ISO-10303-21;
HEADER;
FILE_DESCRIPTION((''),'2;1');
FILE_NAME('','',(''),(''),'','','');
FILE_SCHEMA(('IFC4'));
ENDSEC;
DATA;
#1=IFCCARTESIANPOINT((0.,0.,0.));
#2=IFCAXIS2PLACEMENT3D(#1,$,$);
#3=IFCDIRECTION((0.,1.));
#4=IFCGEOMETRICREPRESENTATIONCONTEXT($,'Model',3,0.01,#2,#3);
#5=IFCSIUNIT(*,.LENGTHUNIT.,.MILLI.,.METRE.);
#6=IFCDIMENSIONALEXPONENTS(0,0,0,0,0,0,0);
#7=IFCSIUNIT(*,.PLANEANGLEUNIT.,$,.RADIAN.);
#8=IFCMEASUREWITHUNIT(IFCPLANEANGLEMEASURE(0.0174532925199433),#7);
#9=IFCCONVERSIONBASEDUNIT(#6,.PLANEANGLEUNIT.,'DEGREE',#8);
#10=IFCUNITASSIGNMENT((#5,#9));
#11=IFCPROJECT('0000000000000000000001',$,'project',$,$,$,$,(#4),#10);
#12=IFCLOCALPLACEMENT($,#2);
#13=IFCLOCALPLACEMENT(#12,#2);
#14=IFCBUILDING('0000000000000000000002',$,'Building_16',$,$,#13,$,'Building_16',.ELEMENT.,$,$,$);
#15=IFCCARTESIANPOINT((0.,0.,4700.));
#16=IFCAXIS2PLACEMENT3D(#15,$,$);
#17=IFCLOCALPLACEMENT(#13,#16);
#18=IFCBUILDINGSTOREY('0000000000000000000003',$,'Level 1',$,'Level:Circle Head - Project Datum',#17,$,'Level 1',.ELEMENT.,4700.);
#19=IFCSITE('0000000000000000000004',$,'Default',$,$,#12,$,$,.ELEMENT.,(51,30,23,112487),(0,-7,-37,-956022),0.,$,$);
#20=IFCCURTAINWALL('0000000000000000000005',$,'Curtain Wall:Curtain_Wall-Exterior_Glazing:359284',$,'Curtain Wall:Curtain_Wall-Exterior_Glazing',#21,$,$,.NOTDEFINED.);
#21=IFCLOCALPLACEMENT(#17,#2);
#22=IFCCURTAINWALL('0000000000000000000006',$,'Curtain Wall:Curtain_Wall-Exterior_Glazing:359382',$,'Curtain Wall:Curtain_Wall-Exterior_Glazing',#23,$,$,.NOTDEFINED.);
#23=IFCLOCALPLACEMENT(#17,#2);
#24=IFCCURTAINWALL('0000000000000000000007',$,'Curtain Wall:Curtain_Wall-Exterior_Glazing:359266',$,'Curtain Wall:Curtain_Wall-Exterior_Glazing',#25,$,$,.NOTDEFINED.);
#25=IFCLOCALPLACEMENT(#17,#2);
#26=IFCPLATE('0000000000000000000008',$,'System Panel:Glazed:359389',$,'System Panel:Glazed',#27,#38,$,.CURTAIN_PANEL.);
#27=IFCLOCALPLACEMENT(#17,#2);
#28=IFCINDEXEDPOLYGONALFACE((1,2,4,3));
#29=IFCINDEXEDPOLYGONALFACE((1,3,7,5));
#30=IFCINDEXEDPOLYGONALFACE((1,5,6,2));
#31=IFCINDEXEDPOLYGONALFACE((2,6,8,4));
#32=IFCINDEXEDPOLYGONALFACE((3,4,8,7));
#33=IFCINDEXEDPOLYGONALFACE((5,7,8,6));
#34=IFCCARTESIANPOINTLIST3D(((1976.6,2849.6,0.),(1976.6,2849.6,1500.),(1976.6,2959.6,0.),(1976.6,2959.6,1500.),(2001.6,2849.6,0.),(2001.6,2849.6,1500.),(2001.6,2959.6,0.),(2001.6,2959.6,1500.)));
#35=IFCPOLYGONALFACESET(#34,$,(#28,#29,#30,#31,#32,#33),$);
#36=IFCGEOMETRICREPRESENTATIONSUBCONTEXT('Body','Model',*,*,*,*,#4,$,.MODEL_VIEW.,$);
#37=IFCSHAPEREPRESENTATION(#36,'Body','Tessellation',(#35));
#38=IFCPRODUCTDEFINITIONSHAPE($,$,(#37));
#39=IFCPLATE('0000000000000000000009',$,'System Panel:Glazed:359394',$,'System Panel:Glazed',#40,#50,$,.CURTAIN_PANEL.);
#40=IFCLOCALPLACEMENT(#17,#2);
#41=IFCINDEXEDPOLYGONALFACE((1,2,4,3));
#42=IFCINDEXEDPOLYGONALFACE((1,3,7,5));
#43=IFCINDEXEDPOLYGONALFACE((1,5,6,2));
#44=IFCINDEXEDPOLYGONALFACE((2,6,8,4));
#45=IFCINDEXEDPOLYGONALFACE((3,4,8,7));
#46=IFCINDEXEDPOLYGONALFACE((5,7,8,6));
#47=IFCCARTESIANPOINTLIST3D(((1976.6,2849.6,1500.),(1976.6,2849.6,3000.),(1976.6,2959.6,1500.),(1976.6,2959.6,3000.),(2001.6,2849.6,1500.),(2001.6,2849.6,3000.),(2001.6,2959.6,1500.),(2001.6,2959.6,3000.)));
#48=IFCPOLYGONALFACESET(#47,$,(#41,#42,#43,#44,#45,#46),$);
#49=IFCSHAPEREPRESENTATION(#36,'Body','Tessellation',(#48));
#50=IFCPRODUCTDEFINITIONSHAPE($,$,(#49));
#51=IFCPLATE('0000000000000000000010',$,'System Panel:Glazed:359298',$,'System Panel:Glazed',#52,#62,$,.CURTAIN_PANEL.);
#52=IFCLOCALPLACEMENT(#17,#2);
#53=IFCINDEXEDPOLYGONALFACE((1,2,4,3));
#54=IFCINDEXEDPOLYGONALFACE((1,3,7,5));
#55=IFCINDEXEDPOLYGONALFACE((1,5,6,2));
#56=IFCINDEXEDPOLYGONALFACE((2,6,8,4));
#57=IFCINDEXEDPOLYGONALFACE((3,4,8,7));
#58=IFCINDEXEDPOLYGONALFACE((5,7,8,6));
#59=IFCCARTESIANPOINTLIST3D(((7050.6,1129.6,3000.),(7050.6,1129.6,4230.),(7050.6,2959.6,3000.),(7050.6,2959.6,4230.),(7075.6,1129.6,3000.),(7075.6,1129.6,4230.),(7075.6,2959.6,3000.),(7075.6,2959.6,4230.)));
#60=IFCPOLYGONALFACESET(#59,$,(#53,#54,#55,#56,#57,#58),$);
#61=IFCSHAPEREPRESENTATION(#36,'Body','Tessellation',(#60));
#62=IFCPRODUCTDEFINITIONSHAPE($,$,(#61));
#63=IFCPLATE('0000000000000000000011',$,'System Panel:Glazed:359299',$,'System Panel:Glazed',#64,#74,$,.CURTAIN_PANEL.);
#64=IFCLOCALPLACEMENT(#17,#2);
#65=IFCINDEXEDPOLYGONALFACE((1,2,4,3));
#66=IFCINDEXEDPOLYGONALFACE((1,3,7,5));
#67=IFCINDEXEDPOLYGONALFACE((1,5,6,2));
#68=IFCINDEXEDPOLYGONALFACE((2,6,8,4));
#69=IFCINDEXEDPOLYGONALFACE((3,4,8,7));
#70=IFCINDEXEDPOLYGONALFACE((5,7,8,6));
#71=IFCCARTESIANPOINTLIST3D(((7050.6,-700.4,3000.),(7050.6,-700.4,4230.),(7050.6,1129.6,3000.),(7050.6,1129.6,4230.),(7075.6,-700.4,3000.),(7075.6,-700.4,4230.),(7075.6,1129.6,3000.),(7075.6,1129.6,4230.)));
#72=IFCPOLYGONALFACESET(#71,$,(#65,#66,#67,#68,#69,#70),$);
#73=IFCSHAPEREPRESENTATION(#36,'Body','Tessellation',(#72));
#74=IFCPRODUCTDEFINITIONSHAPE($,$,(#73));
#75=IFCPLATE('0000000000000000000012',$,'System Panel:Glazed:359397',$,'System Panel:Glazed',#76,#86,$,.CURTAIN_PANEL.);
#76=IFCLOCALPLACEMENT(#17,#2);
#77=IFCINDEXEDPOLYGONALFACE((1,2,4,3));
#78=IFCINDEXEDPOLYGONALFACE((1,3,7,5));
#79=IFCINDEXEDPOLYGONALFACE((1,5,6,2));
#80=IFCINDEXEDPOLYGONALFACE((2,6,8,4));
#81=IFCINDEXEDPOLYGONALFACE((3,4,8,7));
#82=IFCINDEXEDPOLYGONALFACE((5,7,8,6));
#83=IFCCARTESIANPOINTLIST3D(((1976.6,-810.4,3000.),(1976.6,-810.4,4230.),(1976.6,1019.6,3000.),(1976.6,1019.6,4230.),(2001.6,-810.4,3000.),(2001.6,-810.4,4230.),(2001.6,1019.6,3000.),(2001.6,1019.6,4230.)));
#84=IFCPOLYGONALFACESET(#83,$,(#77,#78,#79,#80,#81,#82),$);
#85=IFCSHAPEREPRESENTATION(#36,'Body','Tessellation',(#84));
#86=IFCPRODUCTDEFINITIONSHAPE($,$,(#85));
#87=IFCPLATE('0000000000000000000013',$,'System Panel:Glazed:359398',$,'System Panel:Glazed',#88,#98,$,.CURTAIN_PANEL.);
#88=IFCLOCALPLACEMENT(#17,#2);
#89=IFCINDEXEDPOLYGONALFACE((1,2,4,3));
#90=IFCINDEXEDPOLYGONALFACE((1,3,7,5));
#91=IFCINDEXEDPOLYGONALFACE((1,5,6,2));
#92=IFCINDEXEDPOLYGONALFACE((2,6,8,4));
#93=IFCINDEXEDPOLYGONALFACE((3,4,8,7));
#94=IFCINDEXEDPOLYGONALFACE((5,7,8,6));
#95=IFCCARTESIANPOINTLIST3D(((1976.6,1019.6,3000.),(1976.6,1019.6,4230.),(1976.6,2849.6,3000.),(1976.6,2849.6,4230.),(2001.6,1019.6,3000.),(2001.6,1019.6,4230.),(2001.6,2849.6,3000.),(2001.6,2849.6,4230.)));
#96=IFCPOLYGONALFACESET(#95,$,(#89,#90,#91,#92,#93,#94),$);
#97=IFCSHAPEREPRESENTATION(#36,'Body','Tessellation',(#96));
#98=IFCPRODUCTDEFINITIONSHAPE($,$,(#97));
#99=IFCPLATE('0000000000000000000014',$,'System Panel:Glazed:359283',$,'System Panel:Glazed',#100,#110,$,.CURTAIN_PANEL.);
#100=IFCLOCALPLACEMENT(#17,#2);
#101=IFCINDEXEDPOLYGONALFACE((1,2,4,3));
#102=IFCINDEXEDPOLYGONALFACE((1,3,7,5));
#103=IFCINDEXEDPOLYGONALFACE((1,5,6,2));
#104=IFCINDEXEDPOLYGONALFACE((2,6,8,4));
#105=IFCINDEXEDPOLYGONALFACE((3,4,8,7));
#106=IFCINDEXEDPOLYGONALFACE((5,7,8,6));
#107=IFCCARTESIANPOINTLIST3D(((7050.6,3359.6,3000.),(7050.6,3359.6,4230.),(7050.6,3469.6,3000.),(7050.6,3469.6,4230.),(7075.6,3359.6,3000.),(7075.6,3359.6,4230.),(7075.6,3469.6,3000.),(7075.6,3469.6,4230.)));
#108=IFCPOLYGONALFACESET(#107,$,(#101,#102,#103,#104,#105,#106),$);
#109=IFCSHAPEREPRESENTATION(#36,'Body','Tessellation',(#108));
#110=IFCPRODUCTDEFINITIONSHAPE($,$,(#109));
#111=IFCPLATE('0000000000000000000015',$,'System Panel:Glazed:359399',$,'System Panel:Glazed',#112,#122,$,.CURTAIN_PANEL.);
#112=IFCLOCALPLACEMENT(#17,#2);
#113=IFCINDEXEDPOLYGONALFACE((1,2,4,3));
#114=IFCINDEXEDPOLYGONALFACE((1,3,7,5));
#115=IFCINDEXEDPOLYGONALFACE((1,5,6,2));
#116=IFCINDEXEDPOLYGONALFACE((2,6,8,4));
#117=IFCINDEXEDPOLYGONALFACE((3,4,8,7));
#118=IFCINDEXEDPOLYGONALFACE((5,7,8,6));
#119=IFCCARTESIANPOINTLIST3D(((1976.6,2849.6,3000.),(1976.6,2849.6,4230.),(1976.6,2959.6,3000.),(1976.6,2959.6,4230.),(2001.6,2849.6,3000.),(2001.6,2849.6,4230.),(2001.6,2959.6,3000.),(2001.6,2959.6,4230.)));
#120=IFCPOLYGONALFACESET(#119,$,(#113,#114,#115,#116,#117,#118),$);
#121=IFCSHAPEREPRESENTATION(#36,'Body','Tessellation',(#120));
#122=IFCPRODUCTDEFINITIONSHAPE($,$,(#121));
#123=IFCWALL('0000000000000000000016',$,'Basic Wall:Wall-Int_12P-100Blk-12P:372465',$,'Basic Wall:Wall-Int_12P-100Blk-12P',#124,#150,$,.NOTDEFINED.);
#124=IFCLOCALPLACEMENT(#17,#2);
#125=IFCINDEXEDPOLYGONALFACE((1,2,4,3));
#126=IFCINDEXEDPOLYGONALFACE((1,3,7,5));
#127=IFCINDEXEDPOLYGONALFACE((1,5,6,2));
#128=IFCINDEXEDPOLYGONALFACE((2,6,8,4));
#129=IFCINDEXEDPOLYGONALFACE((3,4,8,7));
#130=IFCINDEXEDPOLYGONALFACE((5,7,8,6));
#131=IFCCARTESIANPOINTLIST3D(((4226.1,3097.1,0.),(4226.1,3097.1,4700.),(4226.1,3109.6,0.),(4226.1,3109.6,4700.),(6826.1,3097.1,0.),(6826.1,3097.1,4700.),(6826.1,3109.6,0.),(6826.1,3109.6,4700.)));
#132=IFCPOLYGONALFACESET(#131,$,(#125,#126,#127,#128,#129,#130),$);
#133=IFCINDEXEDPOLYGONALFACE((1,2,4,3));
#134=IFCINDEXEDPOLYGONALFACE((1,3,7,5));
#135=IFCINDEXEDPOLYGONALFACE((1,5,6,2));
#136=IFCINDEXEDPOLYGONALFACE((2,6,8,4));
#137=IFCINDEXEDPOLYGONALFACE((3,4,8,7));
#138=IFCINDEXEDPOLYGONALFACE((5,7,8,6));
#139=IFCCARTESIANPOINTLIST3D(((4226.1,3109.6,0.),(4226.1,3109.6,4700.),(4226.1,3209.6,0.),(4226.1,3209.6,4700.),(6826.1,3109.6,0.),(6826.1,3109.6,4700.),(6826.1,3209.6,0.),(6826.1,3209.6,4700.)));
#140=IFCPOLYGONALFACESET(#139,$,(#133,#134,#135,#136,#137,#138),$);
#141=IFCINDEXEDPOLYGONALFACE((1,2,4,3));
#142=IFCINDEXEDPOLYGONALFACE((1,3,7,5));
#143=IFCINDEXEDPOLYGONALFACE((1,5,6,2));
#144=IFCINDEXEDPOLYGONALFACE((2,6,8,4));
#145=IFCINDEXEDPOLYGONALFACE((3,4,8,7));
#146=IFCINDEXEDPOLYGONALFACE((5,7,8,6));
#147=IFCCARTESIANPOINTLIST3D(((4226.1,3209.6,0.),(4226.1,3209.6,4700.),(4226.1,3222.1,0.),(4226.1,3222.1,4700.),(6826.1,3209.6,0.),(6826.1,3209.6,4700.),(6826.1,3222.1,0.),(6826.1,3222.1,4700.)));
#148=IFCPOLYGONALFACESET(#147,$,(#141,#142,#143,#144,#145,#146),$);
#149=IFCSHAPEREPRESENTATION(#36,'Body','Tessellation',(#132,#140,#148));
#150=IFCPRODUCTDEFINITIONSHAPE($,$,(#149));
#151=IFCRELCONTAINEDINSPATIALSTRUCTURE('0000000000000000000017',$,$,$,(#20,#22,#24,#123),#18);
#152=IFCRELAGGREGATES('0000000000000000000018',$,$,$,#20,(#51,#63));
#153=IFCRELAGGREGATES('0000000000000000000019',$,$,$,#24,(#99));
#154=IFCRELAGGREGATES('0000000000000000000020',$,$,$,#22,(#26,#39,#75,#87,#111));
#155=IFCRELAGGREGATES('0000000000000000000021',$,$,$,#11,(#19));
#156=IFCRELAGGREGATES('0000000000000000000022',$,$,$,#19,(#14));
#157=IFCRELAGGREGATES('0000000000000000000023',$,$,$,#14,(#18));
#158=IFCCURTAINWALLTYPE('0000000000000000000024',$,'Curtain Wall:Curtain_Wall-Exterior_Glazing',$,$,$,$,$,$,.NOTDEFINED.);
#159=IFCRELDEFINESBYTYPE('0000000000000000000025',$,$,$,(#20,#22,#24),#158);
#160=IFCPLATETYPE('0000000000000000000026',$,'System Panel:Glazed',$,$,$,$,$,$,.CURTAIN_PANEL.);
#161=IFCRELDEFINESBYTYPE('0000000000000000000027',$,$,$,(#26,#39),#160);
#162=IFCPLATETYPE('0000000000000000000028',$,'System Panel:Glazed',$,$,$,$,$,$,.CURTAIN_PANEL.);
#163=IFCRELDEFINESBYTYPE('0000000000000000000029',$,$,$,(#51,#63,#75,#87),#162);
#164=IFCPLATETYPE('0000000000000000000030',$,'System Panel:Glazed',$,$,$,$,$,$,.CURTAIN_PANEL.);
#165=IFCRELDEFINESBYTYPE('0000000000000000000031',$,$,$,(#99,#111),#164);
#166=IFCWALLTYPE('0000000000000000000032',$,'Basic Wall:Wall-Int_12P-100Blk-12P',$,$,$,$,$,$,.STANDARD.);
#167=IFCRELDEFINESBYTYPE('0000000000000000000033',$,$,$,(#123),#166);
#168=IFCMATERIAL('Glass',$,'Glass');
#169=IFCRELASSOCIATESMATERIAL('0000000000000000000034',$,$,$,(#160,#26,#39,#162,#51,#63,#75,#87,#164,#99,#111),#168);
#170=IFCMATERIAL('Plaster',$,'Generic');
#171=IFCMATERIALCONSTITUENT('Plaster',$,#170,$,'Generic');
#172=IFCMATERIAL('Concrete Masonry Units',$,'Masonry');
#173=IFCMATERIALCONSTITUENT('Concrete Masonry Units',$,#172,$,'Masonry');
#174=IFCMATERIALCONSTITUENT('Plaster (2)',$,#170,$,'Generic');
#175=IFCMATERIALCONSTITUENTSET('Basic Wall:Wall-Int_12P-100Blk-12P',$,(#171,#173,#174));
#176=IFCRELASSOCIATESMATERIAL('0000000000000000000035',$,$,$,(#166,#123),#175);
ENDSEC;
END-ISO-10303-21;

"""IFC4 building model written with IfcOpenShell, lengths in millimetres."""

from ifc_helpers import new_model, entity, si_unit, converted_unit, direction, frame, origin, place, context, subcontext, project, spatial, indexed_curve, outline, extrude, source, transform, mapped, material, constituent, constituent_set, type_object, type_shapes, element, aggregate, save


model = new_model("IFC4")

# Units and contexts
model_context = context("Model", 3, precision=0.01, world=origin(), true_north=direction((0.0, 1.0)))
body_context = subcontext(model_context, "Body", "Model", "MODEL_VIEW")
ifc_project = project(units=[si_unit("LENGTHUNIT", "METRE", prefix="MILLI"), converted_unit("PLANEANGLEUNIT", "DEGREE", entity("IfcPlaneAngleMeasure", 0.0174532925199433), si_unit("PLANEANGLEUNIT", "RADIAN"), dimensions=[0, 0, 0, 0, 0, 0, 0])], contexts=[model_context])

# Site, building, storey
site_placement = place(None, origin())
site = spatial("IfcSite", under=ifc_project, at=site_placement, Name="Default", CompositionType="ELEMENT", RefLatitude=(51, 30, 23, 112487), RefLongitude=(0, -7, -37, -956022), RefElevation=0.0)
building_placement = place(site_placement, origin())
building = spatial("IfcBuilding", under=site, at=building_placement, Name="Building_16", LongName="Building_16", CompositionType="ELEMENT")
storey_placement = place(building_placement, frame((0.0, 0.0, 4700.0)))
storey = spatial("IfcBuildingStorey", under=building, at=storey_placement, Name="Level 1", ObjectType="Level:Circle Head - Project Datum", LongName="Level 1", CompositionType="ELEMENT", Elevation=4700.0)

# Shared definitions
ifc_material_1 = material(Name="Plaster", Category="Generic")

# Curtain walls
curtain_wall_type = type_object("IfcCurtainWallType", Name="Curtain Wall:Curtain_Wall-Exterior_Glazing", PredefinedType="NOTDEFINED")
curtain_wall_1_placement = place(storey_placement, frame((0.0, 0.0, -4700.0)))
curtain_wall_1 = element("IfcCurtainWall", 1, at=curtain_wall_1_placement, inside=storey, type_object=curtain_wall_type, Name="Curtain Wall:Curtain_Wall-Exterior_Glazing:359284", ObjectType="Curtain Wall:Curtain_Wall-Exterior_Glazing", PredefinedType="NOTDEFINED")
ifc_material_2 = material(Name="Glass", Category="Glass")
curtain_wall_2_placement = place(storey_placement, frame((0.0, 0.0, -4700.0)))
curtain_wall_2 = element("IfcCurtainWall", 2, at=curtain_wall_2_placement, inside=storey, type_object=curtain_wall_type, Name="Curtain Wall:Curtain_Wall-Exterior_Glazing:359382", ObjectType="Curtain Wall:Curtain_Wall-Exterior_Glazing", PredefinedType="NOTDEFINED")
curtain_wall_3_placement = place(storey_placement, frame((0.0, 0.0, -4700.0)))
curtain_wall_3 = element("IfcCurtainWall", 3, at=curtain_wall_3_placement, inside=storey, type_object=curtain_wall_type, Name="Curtain Wall:Curtain_Wall-Exterior_Glazing:359266", ObjectType="Curtain Wall:Curtain_Wall-Exterior_Glazing", PredefinedType="NOTDEFINED")
plate_type_1 = type_object("IfcPlateType", Name="System Panel:Glazed", PredefinedType="CURTAIN_PANEL", material=ifc_material_2)
shared_shape_1 = source(origin(), body_context, "Body", "SweptSolid", [
    extrude(outline(indexed_curve([(-12.5, -55.0), (12.5, -55.0), (12.5, 55.0), (-12.5, 55.0), (-12.5, -55.0)], self_intersect=False)), frame((0.0, 37.0, 0.0), z_axis=(0.0, 0.0, 1.0), x_axis=(0.0, 1.0, 0.0)), (0.0, 0.0, 1.0), 1500.0),
])
type_shapes(plate_type_1, [shared_shape_1])

# Plates
plate_1_placement = place(curtain_wall_2_placement, frame((2026.1, 2904.6, 4700.0), z_axis=(0.0, 0.0, 1.0), x_axis=(0.0, 1.0, 0.0)))
plate_1 = element("IfcPlate", 4, at=plate_1_placement, type_object=plate_type_1, material=ifc_material_2, Name="System Panel:Glazed:359389", ObjectType="System Panel:Glazed", PredefinedType="CURTAIN_PANEL", context=body_context, shape_type="MappedRepresentation", body=[
    mapped(shared_shape_1, transform((0.0, 0.0, 0.0), scale=1.0)),
])
plate_2_placement = place(curtain_wall_2_placement, frame((2026.1, 2904.6, 6200.0), z_axis=(0.0, 0.0, 1.0), x_axis=(0.0, 1.0, 0.0)))
plate_2 = element("IfcPlate", 5, at=plate_2_placement, type_object=plate_type_1, material=ifc_material_2, Name="System Panel:Glazed:359394", ObjectType="System Panel:Glazed", PredefinedType="CURTAIN_PANEL", context=body_context, shape_type="MappedRepresentation", body=[
    mapped(shared_shape_1, transform((0.0, 0.0, 0.0), scale=1.0)),
])
plate_type_2 = type_object("IfcPlateType", Name="System Panel:Glazed", PredefinedType="CURTAIN_PANEL", material=ifc_material_2)
shared_shape_2 = source(origin(), body_context, "Body", "SweptSolid", [
    extrude(outline(indexed_curve([(-12.5, -915.0), (12.5, -915.0), (12.5, 915.0), (-12.5, 915.0), (-12.5, -915.0)], self_intersect=False)), frame((0.0, 37.0, 0.0), z_axis=(0.0, 0.0, 1.0), x_axis=(0.0, 1.0, 0.0)), (0.0, 0.0, 1.0), 1230.0),
])
type_shapes(plate_type_2, [shared_shape_2])
plate_3_placement = place(curtain_wall_1_placement, frame((7026.1, 2044.6, 7700.0), z_axis=(0.0, 0.0, 1.0), x_axis=(0.0, -1.0, 0.0)))
plate_3 = element("IfcPlate", 6, at=plate_3_placement, type_object=plate_type_2, material=ifc_material_2, Name="System Panel:Glazed:359298", ObjectType="System Panel:Glazed", PredefinedType="CURTAIN_PANEL", context=body_context, shape_type="MappedRepresentation", body=[
    mapped(shared_shape_2, transform((0.0, 0.0, 0.0), scale=1.0)),
])
plate_4_placement = place(curtain_wall_1_placement, frame((7026.1, 214.6, 7700.0), z_axis=(0.0, 0.0, 1.0), x_axis=(0.0, -1.0, 0.0)))
plate_4 = element("IfcPlate", 7, at=plate_4_placement, type_object=plate_type_2, material=ifc_material_2, Name="System Panel:Glazed:359299", ObjectType="System Panel:Glazed", PredefinedType="CURTAIN_PANEL", context=body_context, shape_type="MappedRepresentation", body=[
    mapped(shared_shape_2, transform((0.0, 0.0, 0.0), scale=1.0)),
])
aggregate(curtain_wall_1, [plate_3, plate_4])
plate_5_placement = place(curtain_wall_2_placement, frame((2026.1, 104.6, 7700.0), z_axis=(0.0, 0.0, 1.0), x_axis=(0.0, 1.0, 0.0)))
plate_5 = element("IfcPlate", 8, at=plate_5_placement, type_object=plate_type_2, material=ifc_material_2, Name="System Panel:Glazed:359397", ObjectType="System Panel:Glazed", PredefinedType="CURTAIN_PANEL", context=body_context, shape_type="MappedRepresentation", body=[
    mapped(shared_shape_2, transform((0.0, 0.0, 0.0), scale=1.0)),
])
plate_6_placement = place(curtain_wall_2_placement, frame((2026.1, 1934.6, 7700.0), z_axis=(0.0, 0.0, 1.0), x_axis=(0.0, 1.0, 0.0)))
plate_6 = element("IfcPlate", 9, at=plate_6_placement, type_object=plate_type_2, material=ifc_material_2, Name="System Panel:Glazed:359398", ObjectType="System Panel:Glazed", PredefinedType="CURTAIN_PANEL", context=body_context, shape_type="MappedRepresentation", body=[
    mapped(shared_shape_2, transform((0.0, 0.0, 0.0), scale=1.0)),
])
plate_type_3 = type_object("IfcPlateType", Name="System Panel:Glazed", PredefinedType="CURTAIN_PANEL", material=ifc_material_2)
shared_shape_3 = source(origin(), body_context, "Body", "SweptSolid", [
    extrude(outline(indexed_curve([(-12.5, -55.0), (12.5, -55.0), (12.5, 55.0), (-12.5, 55.0), (-12.5, -55.0)], self_intersect=False)), frame((0.0, 37.0, 0.0), z_axis=(0.0, 0.0, 1.0), x_axis=(0.0, 1.0, 0.0)), (0.0, 0.0, 1.0), 1230.0),
])
type_shapes(plate_type_3, [shared_shape_3])
plate_7_placement = place(curtain_wall_3_placement, frame((7026.1, 3414.6, 7700.0), z_axis=(0.0, 0.0, 1.0), x_axis=(0.0, -1.0, 0.0)))
plate_7 = element("IfcPlate", 10, at=plate_7_placement, type_object=plate_type_3, material=ifc_material_2, Name="System Panel:Glazed:359283", ObjectType="System Panel:Glazed", PredefinedType="CURTAIN_PANEL", context=body_context, shape_type="MappedRepresentation", body=[
    mapped(shared_shape_3, transform((0.0, 0.0, 0.0), scale=1.0)),
])
aggregate(curtain_wall_3, [plate_7])
plate_8_placement = place(curtain_wall_2_placement, frame((2026.1, 2904.6, 7700.0), z_axis=(0.0, 0.0, 1.0), x_axis=(0.0, 1.0, 0.0)))
plate_8 = element("IfcPlate", 11, at=plate_8_placement, type_object=plate_type_3, material=ifc_material_2, Name="System Panel:Glazed:359399", ObjectType="System Panel:Glazed", PredefinedType="CURTAIN_PANEL", context=body_context, shape_type="MappedRepresentation", body=[
    mapped(shared_shape_3, transform((0.0, 0.0, 0.0), scale=1.0)),
])
aggregate(curtain_wall_2, [plate_1, plate_2, plate_5, plate_6, plate_8])

# Wall
ifc_constituent_1 = constituent(ifc_material_1, Name="Plaster", Category="Generic")
ifc_material_3 = material(Name="Concrete Masonry Units", Category="Masonry")
ifc_constituent_2 = constituent(ifc_material_3, Name="Concrete Masonry Units", Category="Masonry")
ifc_constituent_3 = constituent(ifc_material_1, Name="Plaster (2)", Category="Generic")
ifc_constituent_set_1 = constituent_set(constituents=[ifc_constituent_1, ifc_constituent_2, ifc_constituent_3], Name="Basic Wall:Wall-Int_12P-100Blk-12P")
wall_type = type_object("IfcWallType", Name="Basic Wall:Wall-Int_12P-100Blk-12P", PredefinedType="STANDARD", material=ifc_constituent_set_1)
wall_placement = place(storey_placement, frame((4226.1, 3159.6, 0.0)))
element("IfcWall", 12, at=wall_placement, inside=storey, type_object=wall_type, material=ifc_constituent_set_1, Name="Basic Wall:Wall-Int_12P-100Blk-12P:372465", ObjectType="Basic Wall:Wall-Int_12P-100Blk-12P", PredefinedType="NOTDEFINED", context=body_context, shape_type="SweptSolid", body=[
    extrude(outline(indexed_curve([(-6.3, -1300.0), (6.2, -1300.0), (6.3, 1300.0), (-6.2, 1300.0), (-6.3, -1300.0)], self_intersect=False)), frame((1300.0, -56.3, 0.0), z_axis=(0.0, 0.0, 1.0), x_axis=(0.0, 1.0, 0.0)), (0.0, 0.0, 1.0), 4700.0),
    extrude(outline(indexed_curve([(-1300.0, -50.0), (1300.0, -50.0), (1300.0, 50.0), (-1300.0, 50.0), (-1300.0, -50.0)], self_intersect=False)), frame((1300.0, 0.0, 0.0)), (0.0, 0.0, 1.0), 4700.0),
    extrude(outline(indexed_curve([(-6.3, -1300.0), (6.2, -1300.0), (6.3, 1300.0), (-6.2, 1300.0), (-6.3, -1300.0)], self_intersect=False)), frame((1300.0, 56.3, 0.0), z_axis=(0.0, 0.0, 1.0), x_axis=(0.0, -1.0, 0.0)), (0.0, 0.0, 1.0), 4700.0),
])

save(model, "model.ifc")
